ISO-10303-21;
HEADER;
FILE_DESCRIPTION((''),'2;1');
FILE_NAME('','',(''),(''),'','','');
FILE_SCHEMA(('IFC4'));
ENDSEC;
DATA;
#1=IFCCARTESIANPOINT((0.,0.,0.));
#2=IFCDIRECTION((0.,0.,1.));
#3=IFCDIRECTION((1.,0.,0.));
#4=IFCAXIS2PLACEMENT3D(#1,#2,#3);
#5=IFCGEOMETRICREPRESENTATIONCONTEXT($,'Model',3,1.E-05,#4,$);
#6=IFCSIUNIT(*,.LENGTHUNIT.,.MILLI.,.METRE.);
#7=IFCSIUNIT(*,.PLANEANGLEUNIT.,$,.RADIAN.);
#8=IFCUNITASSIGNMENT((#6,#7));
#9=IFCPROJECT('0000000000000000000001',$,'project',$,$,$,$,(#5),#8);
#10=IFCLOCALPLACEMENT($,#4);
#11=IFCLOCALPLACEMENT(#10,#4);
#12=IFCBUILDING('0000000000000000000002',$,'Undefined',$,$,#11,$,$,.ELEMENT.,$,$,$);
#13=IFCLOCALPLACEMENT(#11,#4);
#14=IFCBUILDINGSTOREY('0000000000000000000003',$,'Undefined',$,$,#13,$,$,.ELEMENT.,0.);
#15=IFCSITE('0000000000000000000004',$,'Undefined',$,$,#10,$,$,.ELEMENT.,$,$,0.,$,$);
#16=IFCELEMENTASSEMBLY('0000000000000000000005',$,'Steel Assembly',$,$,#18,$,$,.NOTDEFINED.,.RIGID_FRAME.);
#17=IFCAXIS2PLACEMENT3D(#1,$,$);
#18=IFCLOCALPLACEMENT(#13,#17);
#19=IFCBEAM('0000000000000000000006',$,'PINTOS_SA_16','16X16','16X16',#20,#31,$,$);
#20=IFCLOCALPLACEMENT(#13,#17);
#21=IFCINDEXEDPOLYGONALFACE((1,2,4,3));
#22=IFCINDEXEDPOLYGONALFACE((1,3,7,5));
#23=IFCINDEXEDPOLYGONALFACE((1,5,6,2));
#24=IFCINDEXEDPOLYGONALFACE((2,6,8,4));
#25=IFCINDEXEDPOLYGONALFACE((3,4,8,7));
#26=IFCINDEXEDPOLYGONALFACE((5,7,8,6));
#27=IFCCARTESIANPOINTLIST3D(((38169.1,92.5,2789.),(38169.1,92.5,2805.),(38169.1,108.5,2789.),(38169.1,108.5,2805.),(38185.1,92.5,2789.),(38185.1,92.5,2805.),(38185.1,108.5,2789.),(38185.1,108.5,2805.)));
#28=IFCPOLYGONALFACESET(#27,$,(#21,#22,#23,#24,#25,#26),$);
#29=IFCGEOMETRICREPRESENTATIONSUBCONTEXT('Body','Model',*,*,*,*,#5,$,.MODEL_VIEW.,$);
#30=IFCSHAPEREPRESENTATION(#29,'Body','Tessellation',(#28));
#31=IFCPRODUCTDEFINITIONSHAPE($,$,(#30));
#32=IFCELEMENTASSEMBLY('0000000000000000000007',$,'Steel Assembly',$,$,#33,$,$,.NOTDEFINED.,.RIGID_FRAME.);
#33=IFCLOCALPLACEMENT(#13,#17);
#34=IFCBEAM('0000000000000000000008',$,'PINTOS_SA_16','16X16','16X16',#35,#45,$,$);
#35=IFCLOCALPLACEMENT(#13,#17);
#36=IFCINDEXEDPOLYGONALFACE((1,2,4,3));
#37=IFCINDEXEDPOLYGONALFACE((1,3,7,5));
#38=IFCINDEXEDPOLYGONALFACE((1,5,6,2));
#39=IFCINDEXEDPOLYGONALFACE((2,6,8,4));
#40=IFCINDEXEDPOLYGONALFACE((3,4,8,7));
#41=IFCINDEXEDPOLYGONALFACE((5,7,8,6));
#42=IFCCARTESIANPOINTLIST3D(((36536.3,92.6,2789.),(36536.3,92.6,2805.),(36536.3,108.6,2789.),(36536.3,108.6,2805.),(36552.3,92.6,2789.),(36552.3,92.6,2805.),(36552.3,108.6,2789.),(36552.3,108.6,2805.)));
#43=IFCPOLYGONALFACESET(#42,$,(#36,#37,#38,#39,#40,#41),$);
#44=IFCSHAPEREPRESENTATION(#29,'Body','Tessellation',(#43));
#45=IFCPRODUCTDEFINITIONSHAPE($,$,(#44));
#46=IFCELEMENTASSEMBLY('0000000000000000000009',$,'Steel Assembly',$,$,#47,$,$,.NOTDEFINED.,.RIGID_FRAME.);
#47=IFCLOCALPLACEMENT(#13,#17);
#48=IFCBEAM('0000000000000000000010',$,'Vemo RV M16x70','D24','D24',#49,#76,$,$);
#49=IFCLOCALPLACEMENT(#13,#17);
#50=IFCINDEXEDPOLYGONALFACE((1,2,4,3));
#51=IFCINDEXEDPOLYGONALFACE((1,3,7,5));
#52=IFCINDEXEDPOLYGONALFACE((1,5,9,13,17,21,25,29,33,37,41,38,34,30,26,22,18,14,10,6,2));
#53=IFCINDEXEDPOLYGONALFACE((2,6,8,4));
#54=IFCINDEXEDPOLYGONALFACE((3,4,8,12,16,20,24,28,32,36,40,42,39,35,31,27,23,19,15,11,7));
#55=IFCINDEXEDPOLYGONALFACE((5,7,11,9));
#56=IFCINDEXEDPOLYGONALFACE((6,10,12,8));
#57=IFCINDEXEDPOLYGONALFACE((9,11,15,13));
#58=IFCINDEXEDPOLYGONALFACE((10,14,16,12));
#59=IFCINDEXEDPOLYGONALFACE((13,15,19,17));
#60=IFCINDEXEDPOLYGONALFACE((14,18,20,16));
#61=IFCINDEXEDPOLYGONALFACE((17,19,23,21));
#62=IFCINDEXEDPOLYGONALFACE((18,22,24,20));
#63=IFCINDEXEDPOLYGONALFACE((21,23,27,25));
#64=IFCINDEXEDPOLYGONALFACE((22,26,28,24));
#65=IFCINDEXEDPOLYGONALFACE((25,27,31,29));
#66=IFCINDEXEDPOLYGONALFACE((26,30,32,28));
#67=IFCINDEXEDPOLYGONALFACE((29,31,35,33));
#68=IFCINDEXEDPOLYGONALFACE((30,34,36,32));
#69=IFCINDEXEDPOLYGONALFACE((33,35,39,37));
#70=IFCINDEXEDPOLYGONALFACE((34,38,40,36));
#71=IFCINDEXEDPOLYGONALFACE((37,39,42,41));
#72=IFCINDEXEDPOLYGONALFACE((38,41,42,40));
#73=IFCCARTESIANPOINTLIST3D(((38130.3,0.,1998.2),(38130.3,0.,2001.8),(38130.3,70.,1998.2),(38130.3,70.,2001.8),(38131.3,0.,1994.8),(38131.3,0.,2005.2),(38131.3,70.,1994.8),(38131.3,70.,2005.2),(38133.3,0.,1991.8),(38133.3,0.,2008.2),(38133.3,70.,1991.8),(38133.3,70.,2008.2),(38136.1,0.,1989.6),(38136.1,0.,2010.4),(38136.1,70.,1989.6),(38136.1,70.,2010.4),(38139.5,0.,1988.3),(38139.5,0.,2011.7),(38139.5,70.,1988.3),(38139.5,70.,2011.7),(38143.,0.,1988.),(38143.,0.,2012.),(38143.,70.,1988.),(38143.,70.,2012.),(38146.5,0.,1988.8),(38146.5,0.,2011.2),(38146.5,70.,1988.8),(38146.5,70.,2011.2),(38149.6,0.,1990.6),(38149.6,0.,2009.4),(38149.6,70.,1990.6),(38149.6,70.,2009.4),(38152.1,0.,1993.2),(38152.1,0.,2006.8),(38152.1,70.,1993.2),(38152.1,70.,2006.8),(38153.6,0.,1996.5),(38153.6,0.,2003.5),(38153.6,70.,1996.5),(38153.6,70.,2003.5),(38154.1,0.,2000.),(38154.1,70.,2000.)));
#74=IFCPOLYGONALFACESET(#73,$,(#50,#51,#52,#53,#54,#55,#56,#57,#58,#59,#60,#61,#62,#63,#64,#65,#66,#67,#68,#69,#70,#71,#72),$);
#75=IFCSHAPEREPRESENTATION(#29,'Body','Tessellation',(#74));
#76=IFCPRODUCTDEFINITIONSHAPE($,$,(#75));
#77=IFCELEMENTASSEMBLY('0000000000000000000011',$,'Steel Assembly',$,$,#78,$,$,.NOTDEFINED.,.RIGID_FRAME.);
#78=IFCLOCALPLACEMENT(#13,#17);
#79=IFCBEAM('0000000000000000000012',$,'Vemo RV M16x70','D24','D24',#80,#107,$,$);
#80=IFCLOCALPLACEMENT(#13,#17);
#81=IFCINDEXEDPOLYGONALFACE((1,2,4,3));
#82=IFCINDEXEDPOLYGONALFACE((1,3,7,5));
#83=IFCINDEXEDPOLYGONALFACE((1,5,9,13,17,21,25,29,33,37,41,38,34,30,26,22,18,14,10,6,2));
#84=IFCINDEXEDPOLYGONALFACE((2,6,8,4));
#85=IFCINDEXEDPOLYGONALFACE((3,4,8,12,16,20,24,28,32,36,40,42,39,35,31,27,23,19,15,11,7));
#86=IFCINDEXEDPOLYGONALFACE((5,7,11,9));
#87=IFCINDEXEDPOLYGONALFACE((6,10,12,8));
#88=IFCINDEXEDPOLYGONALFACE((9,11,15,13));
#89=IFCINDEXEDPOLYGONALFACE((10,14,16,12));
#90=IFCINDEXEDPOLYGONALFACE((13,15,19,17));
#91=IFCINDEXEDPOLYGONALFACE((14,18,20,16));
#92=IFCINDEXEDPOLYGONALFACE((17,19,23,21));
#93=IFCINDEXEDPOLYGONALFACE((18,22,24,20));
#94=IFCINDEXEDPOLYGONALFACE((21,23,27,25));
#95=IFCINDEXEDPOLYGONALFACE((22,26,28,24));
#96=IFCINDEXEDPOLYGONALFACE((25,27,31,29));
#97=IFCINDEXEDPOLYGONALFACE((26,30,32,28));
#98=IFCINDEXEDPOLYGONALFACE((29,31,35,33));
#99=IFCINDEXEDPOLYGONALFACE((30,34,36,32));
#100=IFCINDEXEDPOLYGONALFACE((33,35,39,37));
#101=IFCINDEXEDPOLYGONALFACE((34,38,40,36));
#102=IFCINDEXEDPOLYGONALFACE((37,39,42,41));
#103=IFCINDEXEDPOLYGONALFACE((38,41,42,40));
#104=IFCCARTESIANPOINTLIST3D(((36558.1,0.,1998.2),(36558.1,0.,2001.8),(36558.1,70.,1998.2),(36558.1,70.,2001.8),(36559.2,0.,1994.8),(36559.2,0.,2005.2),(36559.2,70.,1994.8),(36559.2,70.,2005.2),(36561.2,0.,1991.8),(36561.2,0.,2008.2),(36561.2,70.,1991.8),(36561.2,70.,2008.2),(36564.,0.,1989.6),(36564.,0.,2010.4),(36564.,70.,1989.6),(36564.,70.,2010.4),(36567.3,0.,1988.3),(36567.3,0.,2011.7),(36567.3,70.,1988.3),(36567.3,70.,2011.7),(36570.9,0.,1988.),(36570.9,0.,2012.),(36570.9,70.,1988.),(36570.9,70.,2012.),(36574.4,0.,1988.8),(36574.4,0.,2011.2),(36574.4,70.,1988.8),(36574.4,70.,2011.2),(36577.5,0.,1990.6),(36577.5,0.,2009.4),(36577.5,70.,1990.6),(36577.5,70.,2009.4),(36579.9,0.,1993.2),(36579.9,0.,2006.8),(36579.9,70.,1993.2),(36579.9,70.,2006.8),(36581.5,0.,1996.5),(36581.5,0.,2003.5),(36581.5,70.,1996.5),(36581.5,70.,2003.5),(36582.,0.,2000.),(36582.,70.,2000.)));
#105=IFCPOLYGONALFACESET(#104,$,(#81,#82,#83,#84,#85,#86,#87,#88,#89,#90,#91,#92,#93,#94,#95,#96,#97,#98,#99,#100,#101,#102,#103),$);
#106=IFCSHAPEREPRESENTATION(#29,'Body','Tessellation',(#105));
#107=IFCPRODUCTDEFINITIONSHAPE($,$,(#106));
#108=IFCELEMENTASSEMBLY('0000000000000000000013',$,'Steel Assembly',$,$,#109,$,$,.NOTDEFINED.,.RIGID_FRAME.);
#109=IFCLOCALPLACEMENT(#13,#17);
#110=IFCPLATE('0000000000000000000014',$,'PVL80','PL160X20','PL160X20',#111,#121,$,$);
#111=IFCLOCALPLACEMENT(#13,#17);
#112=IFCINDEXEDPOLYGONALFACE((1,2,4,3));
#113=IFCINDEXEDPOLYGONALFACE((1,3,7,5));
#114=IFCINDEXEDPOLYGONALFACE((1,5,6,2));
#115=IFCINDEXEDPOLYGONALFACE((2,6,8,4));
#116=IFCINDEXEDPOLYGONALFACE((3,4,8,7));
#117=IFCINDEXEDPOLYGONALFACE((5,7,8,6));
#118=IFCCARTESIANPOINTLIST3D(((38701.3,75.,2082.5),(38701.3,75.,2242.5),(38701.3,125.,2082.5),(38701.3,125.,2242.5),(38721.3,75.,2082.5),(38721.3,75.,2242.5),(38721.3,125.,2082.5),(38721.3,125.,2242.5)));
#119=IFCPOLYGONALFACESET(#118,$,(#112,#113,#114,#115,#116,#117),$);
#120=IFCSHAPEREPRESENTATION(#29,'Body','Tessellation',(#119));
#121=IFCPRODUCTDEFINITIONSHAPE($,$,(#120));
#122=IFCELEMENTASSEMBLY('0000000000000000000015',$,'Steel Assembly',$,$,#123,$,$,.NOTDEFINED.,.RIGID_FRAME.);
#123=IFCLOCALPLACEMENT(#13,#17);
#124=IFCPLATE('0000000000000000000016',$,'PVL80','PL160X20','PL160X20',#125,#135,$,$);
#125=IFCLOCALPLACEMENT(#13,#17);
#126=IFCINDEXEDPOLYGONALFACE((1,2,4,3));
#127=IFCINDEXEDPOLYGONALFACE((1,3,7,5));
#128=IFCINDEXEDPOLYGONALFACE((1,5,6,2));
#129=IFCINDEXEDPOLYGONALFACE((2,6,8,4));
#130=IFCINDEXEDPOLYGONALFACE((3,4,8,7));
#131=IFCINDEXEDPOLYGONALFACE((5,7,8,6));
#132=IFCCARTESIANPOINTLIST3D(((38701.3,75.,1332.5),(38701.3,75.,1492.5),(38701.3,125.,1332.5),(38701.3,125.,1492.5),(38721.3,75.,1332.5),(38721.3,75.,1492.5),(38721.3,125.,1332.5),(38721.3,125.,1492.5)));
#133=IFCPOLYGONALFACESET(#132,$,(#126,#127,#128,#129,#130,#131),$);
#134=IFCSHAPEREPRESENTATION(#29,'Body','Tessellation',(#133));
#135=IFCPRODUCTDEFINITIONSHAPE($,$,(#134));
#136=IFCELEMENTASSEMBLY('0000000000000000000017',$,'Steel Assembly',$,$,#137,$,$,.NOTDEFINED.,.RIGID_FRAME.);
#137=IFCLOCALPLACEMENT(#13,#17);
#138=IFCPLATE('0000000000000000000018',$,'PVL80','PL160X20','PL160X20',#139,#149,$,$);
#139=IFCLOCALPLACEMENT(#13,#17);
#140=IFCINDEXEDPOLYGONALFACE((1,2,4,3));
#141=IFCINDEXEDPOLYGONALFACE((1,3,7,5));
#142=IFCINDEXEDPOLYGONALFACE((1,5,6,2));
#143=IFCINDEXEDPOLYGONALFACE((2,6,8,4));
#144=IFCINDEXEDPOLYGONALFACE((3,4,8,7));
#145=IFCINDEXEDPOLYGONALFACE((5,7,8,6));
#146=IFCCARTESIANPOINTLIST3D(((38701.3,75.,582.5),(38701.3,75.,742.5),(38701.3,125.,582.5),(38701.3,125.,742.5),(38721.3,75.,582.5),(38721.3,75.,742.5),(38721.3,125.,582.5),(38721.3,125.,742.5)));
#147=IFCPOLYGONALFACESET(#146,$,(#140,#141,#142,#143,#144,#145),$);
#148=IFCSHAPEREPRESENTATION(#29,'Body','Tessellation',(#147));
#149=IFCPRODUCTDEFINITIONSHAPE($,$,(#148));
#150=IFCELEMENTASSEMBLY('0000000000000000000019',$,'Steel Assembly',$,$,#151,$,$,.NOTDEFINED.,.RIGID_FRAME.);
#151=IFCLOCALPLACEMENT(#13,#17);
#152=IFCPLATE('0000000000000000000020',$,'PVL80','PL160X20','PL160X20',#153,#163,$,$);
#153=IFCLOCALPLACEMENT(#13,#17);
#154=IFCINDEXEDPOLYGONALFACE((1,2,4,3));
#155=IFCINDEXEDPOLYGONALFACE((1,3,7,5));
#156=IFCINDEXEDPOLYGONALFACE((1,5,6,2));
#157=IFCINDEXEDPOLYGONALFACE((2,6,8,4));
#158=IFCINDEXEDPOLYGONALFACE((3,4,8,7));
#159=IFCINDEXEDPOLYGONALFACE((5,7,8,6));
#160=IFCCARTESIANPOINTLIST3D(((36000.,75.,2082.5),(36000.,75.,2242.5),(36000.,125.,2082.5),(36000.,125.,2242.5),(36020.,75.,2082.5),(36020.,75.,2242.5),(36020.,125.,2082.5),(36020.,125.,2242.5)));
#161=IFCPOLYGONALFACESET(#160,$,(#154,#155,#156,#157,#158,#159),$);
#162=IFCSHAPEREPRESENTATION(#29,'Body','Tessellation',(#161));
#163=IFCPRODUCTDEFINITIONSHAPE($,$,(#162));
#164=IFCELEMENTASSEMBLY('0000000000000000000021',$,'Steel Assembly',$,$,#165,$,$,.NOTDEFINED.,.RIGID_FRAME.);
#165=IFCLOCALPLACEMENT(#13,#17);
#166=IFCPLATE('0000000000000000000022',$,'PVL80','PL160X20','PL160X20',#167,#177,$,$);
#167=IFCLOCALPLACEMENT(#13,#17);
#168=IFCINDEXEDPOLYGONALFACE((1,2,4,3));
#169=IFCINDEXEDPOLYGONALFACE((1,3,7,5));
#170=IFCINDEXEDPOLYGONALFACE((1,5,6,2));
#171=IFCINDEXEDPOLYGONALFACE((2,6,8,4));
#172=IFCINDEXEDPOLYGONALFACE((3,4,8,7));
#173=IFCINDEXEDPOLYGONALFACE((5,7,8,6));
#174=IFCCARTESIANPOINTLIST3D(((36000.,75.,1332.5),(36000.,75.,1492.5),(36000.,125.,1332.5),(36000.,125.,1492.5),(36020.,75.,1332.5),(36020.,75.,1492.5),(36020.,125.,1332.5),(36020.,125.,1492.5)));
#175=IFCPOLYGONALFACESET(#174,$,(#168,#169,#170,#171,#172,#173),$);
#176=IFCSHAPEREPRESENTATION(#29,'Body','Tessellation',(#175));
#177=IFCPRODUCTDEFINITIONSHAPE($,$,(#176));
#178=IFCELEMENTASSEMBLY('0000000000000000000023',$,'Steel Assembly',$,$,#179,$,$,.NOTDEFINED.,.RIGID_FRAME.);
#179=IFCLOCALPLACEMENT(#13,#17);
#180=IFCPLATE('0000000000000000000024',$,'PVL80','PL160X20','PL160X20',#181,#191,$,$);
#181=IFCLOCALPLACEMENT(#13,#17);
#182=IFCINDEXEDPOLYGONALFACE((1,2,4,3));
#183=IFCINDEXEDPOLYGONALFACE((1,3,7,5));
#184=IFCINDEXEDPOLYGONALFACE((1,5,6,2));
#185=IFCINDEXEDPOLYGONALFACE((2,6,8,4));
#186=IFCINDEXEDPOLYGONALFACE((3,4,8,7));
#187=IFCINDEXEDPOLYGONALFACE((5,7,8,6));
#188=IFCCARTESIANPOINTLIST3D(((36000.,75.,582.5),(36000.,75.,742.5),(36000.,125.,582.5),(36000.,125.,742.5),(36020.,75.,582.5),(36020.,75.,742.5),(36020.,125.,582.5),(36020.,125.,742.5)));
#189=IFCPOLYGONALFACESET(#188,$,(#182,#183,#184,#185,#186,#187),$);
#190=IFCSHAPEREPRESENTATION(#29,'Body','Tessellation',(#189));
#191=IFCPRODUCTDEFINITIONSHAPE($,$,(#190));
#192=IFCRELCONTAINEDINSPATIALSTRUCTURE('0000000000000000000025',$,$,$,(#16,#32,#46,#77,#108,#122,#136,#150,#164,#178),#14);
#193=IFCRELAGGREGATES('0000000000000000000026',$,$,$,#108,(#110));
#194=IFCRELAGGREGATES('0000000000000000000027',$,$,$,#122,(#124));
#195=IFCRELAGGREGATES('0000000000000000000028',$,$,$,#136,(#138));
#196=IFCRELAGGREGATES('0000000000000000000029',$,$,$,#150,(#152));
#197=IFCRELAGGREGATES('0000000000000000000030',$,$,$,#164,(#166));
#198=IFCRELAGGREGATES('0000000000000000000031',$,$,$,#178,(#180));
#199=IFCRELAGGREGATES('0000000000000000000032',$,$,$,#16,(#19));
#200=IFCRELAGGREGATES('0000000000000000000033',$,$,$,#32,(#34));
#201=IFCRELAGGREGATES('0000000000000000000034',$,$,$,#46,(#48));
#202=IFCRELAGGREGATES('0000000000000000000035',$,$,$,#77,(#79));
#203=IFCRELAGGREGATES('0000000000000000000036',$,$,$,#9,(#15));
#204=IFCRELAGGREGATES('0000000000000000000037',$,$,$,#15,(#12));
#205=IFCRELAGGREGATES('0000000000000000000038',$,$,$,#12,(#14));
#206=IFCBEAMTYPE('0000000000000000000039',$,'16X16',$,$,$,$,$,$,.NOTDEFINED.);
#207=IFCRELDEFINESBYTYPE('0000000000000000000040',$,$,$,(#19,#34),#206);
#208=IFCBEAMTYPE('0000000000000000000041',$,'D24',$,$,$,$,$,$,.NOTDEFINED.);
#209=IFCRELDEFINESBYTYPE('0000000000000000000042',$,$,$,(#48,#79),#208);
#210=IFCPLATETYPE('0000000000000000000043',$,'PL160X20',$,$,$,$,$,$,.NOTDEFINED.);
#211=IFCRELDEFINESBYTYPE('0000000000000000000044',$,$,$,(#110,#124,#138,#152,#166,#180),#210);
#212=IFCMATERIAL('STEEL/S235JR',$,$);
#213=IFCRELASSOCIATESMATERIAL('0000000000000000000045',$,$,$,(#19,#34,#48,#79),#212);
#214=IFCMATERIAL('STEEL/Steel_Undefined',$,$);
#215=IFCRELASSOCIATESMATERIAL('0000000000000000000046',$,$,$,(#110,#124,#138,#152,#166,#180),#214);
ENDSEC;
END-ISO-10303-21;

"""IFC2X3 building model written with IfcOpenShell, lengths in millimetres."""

from ifc_helpers import new_model, si_unit, frame, frame_2d, origin_with_axes, place, context, subcontext, project, spatial, polyline, rectangle, circle, outline, extrude, material, type_object, element, aggregate, save


model = new_model("IFC2X3")

# Units and contexts
model_context = context("Model", 3, precision=1e-05, world=origin_with_axes())
body_context = subcontext(model_context, "Body", "Model", "MODEL_VIEW")
ifc_project = project(units=[si_unit("LENGTHUNIT", "METRE", prefix="MILLI"), si_unit("PLANEANGLEUNIT", "RADIAN")], contexts=[model_context])

# Site, building, storey
site_placement = place(None, origin_with_axes())
site = spatial("IfcSite", under=ifc_project, at=site_placement, Name="Undefined", CompositionType="ELEMENT", RefElevation=0.0)
building_placement = place(site_placement, origin_with_axes())
building = spatial("IfcBuilding", under=site, at=building_placement, Name="Undefined", CompositionType="ELEMENT")
storey_placement = place(building_placement, origin_with_axes())
storey = spatial("IfcBuildingStorey", under=building, at=storey_placement, Name="Undefined", CompositionType="ELEMENT", Elevation=0.0)

# Element assemblies, beams
assembly_1_placement = place(storey_placement, origin_with_axes())
assembly_1 = element("IfcElementAssembly", 1, at=assembly_1_placement, inside=storey, Name="Steel Assembly", AssemblyPlace="NOTDEFINED", PredefinedType="RIGID_FRAME")
ifc_material_1 = material(Name="STEEL/S235JR")
beam_type_1 = type_object("IfcBeamType", Name="16X16", PredefinedType="NOTDEFINED")
beam_1_placement = place(assembly_1_placement, frame((38185.1, 100.5, 2797.0), z_axis=(0.0, 0.0, 1.0), x_axis=(-1.0, 0.000007, 0.0)))
beam_1 = element("IfcBeam", 2, at=beam_1_placement, type_object=beam_type_1, material=ifc_material_1, Name="PINTOS_SA_16", Description="16X16", ObjectType="16X16", context=body_context, shape_type="SweptSolid", body=[
    extrude(rectangle(XDim=16.0, YDim=16.0, at=frame_2d((0.0, 0.0), x_axis=(1.0, 0.0))), frame((16.0, 0.0, 0.0), z_axis=(-1.0, 0.0, 0.0), x_axis=(0.0, -1.0, 0.0)), (0.0, 0.0, 1.0), 16.0),
])
assembly_2_placement = place(storey_placement, origin_with_axes())
assembly_2 = element("IfcElementAssembly", 3, at=assembly_2_placement, inside=storey, Name="Steel Assembly", AssemblyPlace="NOTDEFINED", PredefinedType="RIGID_FRAME")
beam_2_placement = place(assembly_2_placement, frame((36536.3, 100.6, 2797.0), z_axis=(0.0, 0.0, 1.0), x_axis=(1.0, -0.000007, 0.0)))
beam_2 = element("IfcBeam", 4, at=beam_2_placement, type_object=beam_type_1, material=ifc_material_1, Name="PINTOS_SA_16", Description="16X16", ObjectType="16X16", context=body_context, shape_type="SweptSolid", body=[
    extrude(rectangle(XDim=16.0, YDim=16.0, at=frame_2d((0.0, 0.0), x_axis=(1.0, 0.0))), frame((16.0, 0.0, 0.0), z_axis=(-1.0, 0.0, 0.0), x_axis=(0.0, -1.0, 0.0)), (0.0, 0.0, 1.0), 16.0),
])
assembly_3_placement = place(storey_placement, origin_with_axes())
assembly_3 = element("IfcElementAssembly", 5, at=assembly_3_placement, inside=storey, Name="Steel Assembly", AssemblyPlace="NOTDEFINED", PredefinedType="RIGID_FRAME")
beam_type_2 = type_object("IfcBeamType", Name="D24", PredefinedType="NOTDEFINED")
beam_3_placement = place(assembly_3_placement, frame((38142.1, 0.0, 2000.0), z_axis=(0.0, 0.0, 1.0), x_axis=(0.000007, 1.0, 0.0)))
beam_3 = element("IfcBeam", 6, at=beam_3_placement, type_object=beam_type_2, material=ifc_material_1, Name="Vemo RV M16x70", Description="D24", ObjectType="D24", context=body_context, shape_type="SweptSolid", body=[
    extrude(circle(Radius=12.0, at=frame_2d((0.0, 0.0), x_axis=(1.0, 0.0))), frame((70.0, 0.0, 0.0), z_axis=(-1.0, 0.0, 0.0), x_axis=(0.0, -1.0, 0.0)), (0.0, 0.0, 1.0), 70.0),
])
assembly_4_placement = place(storey_placement, origin_with_axes())
assembly_4 = element("IfcElementAssembly", 7, at=assembly_4_placement, inside=storey, Name="Steel Assembly", AssemblyPlace="NOTDEFINED", PredefinedType="RIGID_FRAME")
beam_4_placement = place(assembly_4_placement, frame((36570.0, 0.0, 2000.0), z_axis=(0.0, 0.0, 1.0), x_axis=(0.000007, 1.0, 0.0)))
beam_4 = element("IfcBeam", 8, at=beam_4_placement, type_object=beam_type_2, material=ifc_material_1, Name="Vemo RV M16x70", Description="D24", ObjectType="D24", context=body_context, shape_type="SweptSolid", body=[
    extrude(circle(Radius=12.0, at=frame_2d((0.0, 0.0), x_axis=(1.0, 0.0))), frame((70.0, 0.0, 0.0), z_axis=(-1.0, 0.0, 0.0), x_axis=(0.0, -1.0, 0.0)), (0.0, 0.0, 1.0), 70.0),
])

# Element assemblies, plates
assembly_5_placement = place(storey_placement, origin_with_axes())
assembly_5 = element("IfcElementAssembly", 9, at=assembly_5_placement, inside=storey, Name="Steel Assembly", AssemblyPlace="NOTDEFINED", PredefinedType="RIGID_FRAME")
ifc_material_2 = material(Name="STEEL/Steel_Undefined")
plate_type = type_object("IfcPlateType", Name="PL160X20", PredefinedType="NOTDEFINED")
plate_1_placement = place(assembly_5_placement, frame((38721.3, 125.0, 2162.5), z_axis=(0.0, 0.0, -1.0), x_axis=(-0.000007, -1.0, 0.0)))
plate_1 = element("IfcPlate", 10, at=plate_1_placement, type_object=plate_type, material=ifc_material_2, Name="PVL80", Description="PL160X20", ObjectType="PL160X20", context=body_context, shape_type="SweptSolid", body=[
    extrude(outline(polyline([(0.0, 0.0), (50.0, 0.0), (50.0, 20.0), (0.0, 20.0), (0.0, 0.0)])), frame((0.0, 0.0, -80.0), z_axis=(0.0, 0.0, 1.0), x_axis=(1.0, 0.0, 0.0)), (0.0, 0.0, 1.0), 160.0),
])
assembly_6_placement = place(storey_placement, origin_with_axes())
assembly_6 = element("IfcElementAssembly", 11, at=assembly_6_placement, inside=storey, Name="Steel Assembly", AssemblyPlace="NOTDEFINED", PredefinedType="RIGID_FRAME")
plate_2_placement = place(assembly_6_placement, frame((38721.3, 125.0, 1412.5), z_axis=(0.0, 0.0, -1.0), x_axis=(-0.000007, -1.0, 0.0)))
plate_2 = element("IfcPlate", 12, at=plate_2_placement, type_object=plate_type, material=ifc_material_2, Name="PVL80", Description="PL160X20", ObjectType="PL160X20", context=body_context, shape_type="SweptSolid", body=[
    extrude(outline(polyline([(0.0, 0.0), (50.0, 0.0), (50.0, 20.0), (0.0, 20.0), (0.0, 0.0)])), frame((0.0, 0.0, -80.0), z_axis=(0.0, 0.0, 1.0), x_axis=(1.0, 0.0, 0.0)), (0.0, 0.0, 1.0), 160.0),
])
assembly_7_placement = place(storey_placement, origin_with_axes())
assembly_7 = element("IfcElementAssembly", 13, at=assembly_7_placement, inside=storey, Name="Steel Assembly", AssemblyPlace="NOTDEFINED", PredefinedType="RIGID_FRAME")
plate_3_placement = place(assembly_7_placement, frame((38721.3, 125.0, 662.5), z_axis=(0.0, 0.0, -1.0), x_axis=(-0.000007, -1.0, 0.0)))
plate_3 = element("IfcPlate", 14, at=plate_3_placement, type_object=plate_type, material=ifc_material_2, Name="PVL80", Description="PL160X20", ObjectType="PL160X20", context=body_context, shape_type="SweptSolid", body=[
    extrude(outline(polyline([(0.0, 0.0), (50.0, 0.0), (50.0, 20.0), (0.0, 20.0), (0.0, 0.0)])), frame((0.0, 0.0, -80.0), z_axis=(0.0, 0.0, 1.0), x_axis=(1.0, 0.0, 0.0)), (0.0, 0.0, 1.0), 160.0),
])
assembly_8_placement = place(storey_placement, origin_with_axes())
assembly_8 = element("IfcElementAssembly", 15, at=assembly_8_placement, inside=storey, Name="Steel Assembly", AssemblyPlace="NOTDEFINED", PredefinedType="RIGID_FRAME")
plate_4_placement = place(assembly_8_placement, frame((36000.0, 75.0, 2162.5), z_axis=(0.0, 0.0, -1.0), x_axis=(0.000007, 1.0, 0.0)))
plate_4 = element("IfcPlate", 16, at=plate_4_placement, type_object=plate_type, material=ifc_material_2, Name="PVL80", Description="PL160X20", ObjectType="PL160X20", context=body_context, shape_type="SweptSolid", body=[
    extrude(outline(polyline([(0.0, 0.0), (50.0, 0.0), (50.0, 20.0), (0.0, 20.0), (0.0, 0.0)])), frame((0.0, 0.0, -80.0), z_axis=(0.0, 0.0, 1.0), x_axis=(1.0, 0.0, 0.0)), (0.0, 0.0, 1.0), 160.0),
])
assembly_9_placement = place(storey_placement, origin_with_axes())
assembly_9 = element("IfcElementAssembly", 17, at=assembly_9_placement, inside=storey, Name="Steel Assembly", AssemblyPlace="NOTDEFINED", PredefinedType="RIGID_FRAME")
plate_5_placement = place(assembly_9_placement, frame((36000.0, 75.0, 1412.5), z_axis=(0.0, 0.0, -1.0), x_axis=(0.000007, 1.0, 0.0)))
plate_5 = element("IfcPlate", 18, at=plate_5_placement, type_object=plate_type, material=ifc_material_2, Name="PVL80", Description="PL160X20", ObjectType="PL160X20", context=body_context, shape_type="SweptSolid", body=[
    extrude(outline(polyline([(0.0, 0.0), (50.0, 0.0), (50.0, 20.0), (0.0, 20.0), (0.0, 0.0)])), frame((0.0, 0.0, -80.0), z_axis=(0.0, 0.0, 1.0), x_axis=(1.0, 0.0, 0.0)), (0.0, 0.0, 1.0), 160.0),
])
assembly_10_placement = place(storey_placement, origin_with_axes())
assembly_10 = element("IfcElementAssembly", 19, at=assembly_10_placement, inside=storey, Name="Steel Assembly", AssemblyPlace="NOTDEFINED", PredefinedType="RIGID_FRAME")
plate_6_placement = place(assembly_10_placement, frame((36000.0, 75.0, 662.5), z_axis=(0.0, 0.0, -1.0), x_axis=(0.000007, 1.0, 0.0)))
plate_6 = element("IfcPlate", 20, at=plate_6_placement, type_object=plate_type, material=ifc_material_2, Name="PVL80", Description="PL160X20", ObjectType="PL160X20", context=body_context, shape_type="SweptSolid", body=[
    extrude(outline(polyline([(0.0, 0.0), (50.0, 0.0), (50.0, 20.0), (0.0, 20.0), (0.0, 0.0)])), frame((0.0, 0.0, -80.0), z_axis=(0.0, 0.0, 1.0), x_axis=(1.0, 0.0, 0.0)), (0.0, 0.0, 1.0), 160.0),
])

aggregate(assembly_5, [plate_1])
aggregate(assembly_6, [plate_2])
aggregate(assembly_7, [plate_3])
aggregate(assembly_8, [plate_4])
aggregate(assembly_9, [plate_5])
aggregate(assembly_10, [plate_6])
aggregate(assembly_1, [beam_1])
aggregate(assembly_2, [beam_2])

aggregate(assembly_3, [beam_3])
aggregate(assembly_4, [beam_4])

save(model, "model.ifc")
